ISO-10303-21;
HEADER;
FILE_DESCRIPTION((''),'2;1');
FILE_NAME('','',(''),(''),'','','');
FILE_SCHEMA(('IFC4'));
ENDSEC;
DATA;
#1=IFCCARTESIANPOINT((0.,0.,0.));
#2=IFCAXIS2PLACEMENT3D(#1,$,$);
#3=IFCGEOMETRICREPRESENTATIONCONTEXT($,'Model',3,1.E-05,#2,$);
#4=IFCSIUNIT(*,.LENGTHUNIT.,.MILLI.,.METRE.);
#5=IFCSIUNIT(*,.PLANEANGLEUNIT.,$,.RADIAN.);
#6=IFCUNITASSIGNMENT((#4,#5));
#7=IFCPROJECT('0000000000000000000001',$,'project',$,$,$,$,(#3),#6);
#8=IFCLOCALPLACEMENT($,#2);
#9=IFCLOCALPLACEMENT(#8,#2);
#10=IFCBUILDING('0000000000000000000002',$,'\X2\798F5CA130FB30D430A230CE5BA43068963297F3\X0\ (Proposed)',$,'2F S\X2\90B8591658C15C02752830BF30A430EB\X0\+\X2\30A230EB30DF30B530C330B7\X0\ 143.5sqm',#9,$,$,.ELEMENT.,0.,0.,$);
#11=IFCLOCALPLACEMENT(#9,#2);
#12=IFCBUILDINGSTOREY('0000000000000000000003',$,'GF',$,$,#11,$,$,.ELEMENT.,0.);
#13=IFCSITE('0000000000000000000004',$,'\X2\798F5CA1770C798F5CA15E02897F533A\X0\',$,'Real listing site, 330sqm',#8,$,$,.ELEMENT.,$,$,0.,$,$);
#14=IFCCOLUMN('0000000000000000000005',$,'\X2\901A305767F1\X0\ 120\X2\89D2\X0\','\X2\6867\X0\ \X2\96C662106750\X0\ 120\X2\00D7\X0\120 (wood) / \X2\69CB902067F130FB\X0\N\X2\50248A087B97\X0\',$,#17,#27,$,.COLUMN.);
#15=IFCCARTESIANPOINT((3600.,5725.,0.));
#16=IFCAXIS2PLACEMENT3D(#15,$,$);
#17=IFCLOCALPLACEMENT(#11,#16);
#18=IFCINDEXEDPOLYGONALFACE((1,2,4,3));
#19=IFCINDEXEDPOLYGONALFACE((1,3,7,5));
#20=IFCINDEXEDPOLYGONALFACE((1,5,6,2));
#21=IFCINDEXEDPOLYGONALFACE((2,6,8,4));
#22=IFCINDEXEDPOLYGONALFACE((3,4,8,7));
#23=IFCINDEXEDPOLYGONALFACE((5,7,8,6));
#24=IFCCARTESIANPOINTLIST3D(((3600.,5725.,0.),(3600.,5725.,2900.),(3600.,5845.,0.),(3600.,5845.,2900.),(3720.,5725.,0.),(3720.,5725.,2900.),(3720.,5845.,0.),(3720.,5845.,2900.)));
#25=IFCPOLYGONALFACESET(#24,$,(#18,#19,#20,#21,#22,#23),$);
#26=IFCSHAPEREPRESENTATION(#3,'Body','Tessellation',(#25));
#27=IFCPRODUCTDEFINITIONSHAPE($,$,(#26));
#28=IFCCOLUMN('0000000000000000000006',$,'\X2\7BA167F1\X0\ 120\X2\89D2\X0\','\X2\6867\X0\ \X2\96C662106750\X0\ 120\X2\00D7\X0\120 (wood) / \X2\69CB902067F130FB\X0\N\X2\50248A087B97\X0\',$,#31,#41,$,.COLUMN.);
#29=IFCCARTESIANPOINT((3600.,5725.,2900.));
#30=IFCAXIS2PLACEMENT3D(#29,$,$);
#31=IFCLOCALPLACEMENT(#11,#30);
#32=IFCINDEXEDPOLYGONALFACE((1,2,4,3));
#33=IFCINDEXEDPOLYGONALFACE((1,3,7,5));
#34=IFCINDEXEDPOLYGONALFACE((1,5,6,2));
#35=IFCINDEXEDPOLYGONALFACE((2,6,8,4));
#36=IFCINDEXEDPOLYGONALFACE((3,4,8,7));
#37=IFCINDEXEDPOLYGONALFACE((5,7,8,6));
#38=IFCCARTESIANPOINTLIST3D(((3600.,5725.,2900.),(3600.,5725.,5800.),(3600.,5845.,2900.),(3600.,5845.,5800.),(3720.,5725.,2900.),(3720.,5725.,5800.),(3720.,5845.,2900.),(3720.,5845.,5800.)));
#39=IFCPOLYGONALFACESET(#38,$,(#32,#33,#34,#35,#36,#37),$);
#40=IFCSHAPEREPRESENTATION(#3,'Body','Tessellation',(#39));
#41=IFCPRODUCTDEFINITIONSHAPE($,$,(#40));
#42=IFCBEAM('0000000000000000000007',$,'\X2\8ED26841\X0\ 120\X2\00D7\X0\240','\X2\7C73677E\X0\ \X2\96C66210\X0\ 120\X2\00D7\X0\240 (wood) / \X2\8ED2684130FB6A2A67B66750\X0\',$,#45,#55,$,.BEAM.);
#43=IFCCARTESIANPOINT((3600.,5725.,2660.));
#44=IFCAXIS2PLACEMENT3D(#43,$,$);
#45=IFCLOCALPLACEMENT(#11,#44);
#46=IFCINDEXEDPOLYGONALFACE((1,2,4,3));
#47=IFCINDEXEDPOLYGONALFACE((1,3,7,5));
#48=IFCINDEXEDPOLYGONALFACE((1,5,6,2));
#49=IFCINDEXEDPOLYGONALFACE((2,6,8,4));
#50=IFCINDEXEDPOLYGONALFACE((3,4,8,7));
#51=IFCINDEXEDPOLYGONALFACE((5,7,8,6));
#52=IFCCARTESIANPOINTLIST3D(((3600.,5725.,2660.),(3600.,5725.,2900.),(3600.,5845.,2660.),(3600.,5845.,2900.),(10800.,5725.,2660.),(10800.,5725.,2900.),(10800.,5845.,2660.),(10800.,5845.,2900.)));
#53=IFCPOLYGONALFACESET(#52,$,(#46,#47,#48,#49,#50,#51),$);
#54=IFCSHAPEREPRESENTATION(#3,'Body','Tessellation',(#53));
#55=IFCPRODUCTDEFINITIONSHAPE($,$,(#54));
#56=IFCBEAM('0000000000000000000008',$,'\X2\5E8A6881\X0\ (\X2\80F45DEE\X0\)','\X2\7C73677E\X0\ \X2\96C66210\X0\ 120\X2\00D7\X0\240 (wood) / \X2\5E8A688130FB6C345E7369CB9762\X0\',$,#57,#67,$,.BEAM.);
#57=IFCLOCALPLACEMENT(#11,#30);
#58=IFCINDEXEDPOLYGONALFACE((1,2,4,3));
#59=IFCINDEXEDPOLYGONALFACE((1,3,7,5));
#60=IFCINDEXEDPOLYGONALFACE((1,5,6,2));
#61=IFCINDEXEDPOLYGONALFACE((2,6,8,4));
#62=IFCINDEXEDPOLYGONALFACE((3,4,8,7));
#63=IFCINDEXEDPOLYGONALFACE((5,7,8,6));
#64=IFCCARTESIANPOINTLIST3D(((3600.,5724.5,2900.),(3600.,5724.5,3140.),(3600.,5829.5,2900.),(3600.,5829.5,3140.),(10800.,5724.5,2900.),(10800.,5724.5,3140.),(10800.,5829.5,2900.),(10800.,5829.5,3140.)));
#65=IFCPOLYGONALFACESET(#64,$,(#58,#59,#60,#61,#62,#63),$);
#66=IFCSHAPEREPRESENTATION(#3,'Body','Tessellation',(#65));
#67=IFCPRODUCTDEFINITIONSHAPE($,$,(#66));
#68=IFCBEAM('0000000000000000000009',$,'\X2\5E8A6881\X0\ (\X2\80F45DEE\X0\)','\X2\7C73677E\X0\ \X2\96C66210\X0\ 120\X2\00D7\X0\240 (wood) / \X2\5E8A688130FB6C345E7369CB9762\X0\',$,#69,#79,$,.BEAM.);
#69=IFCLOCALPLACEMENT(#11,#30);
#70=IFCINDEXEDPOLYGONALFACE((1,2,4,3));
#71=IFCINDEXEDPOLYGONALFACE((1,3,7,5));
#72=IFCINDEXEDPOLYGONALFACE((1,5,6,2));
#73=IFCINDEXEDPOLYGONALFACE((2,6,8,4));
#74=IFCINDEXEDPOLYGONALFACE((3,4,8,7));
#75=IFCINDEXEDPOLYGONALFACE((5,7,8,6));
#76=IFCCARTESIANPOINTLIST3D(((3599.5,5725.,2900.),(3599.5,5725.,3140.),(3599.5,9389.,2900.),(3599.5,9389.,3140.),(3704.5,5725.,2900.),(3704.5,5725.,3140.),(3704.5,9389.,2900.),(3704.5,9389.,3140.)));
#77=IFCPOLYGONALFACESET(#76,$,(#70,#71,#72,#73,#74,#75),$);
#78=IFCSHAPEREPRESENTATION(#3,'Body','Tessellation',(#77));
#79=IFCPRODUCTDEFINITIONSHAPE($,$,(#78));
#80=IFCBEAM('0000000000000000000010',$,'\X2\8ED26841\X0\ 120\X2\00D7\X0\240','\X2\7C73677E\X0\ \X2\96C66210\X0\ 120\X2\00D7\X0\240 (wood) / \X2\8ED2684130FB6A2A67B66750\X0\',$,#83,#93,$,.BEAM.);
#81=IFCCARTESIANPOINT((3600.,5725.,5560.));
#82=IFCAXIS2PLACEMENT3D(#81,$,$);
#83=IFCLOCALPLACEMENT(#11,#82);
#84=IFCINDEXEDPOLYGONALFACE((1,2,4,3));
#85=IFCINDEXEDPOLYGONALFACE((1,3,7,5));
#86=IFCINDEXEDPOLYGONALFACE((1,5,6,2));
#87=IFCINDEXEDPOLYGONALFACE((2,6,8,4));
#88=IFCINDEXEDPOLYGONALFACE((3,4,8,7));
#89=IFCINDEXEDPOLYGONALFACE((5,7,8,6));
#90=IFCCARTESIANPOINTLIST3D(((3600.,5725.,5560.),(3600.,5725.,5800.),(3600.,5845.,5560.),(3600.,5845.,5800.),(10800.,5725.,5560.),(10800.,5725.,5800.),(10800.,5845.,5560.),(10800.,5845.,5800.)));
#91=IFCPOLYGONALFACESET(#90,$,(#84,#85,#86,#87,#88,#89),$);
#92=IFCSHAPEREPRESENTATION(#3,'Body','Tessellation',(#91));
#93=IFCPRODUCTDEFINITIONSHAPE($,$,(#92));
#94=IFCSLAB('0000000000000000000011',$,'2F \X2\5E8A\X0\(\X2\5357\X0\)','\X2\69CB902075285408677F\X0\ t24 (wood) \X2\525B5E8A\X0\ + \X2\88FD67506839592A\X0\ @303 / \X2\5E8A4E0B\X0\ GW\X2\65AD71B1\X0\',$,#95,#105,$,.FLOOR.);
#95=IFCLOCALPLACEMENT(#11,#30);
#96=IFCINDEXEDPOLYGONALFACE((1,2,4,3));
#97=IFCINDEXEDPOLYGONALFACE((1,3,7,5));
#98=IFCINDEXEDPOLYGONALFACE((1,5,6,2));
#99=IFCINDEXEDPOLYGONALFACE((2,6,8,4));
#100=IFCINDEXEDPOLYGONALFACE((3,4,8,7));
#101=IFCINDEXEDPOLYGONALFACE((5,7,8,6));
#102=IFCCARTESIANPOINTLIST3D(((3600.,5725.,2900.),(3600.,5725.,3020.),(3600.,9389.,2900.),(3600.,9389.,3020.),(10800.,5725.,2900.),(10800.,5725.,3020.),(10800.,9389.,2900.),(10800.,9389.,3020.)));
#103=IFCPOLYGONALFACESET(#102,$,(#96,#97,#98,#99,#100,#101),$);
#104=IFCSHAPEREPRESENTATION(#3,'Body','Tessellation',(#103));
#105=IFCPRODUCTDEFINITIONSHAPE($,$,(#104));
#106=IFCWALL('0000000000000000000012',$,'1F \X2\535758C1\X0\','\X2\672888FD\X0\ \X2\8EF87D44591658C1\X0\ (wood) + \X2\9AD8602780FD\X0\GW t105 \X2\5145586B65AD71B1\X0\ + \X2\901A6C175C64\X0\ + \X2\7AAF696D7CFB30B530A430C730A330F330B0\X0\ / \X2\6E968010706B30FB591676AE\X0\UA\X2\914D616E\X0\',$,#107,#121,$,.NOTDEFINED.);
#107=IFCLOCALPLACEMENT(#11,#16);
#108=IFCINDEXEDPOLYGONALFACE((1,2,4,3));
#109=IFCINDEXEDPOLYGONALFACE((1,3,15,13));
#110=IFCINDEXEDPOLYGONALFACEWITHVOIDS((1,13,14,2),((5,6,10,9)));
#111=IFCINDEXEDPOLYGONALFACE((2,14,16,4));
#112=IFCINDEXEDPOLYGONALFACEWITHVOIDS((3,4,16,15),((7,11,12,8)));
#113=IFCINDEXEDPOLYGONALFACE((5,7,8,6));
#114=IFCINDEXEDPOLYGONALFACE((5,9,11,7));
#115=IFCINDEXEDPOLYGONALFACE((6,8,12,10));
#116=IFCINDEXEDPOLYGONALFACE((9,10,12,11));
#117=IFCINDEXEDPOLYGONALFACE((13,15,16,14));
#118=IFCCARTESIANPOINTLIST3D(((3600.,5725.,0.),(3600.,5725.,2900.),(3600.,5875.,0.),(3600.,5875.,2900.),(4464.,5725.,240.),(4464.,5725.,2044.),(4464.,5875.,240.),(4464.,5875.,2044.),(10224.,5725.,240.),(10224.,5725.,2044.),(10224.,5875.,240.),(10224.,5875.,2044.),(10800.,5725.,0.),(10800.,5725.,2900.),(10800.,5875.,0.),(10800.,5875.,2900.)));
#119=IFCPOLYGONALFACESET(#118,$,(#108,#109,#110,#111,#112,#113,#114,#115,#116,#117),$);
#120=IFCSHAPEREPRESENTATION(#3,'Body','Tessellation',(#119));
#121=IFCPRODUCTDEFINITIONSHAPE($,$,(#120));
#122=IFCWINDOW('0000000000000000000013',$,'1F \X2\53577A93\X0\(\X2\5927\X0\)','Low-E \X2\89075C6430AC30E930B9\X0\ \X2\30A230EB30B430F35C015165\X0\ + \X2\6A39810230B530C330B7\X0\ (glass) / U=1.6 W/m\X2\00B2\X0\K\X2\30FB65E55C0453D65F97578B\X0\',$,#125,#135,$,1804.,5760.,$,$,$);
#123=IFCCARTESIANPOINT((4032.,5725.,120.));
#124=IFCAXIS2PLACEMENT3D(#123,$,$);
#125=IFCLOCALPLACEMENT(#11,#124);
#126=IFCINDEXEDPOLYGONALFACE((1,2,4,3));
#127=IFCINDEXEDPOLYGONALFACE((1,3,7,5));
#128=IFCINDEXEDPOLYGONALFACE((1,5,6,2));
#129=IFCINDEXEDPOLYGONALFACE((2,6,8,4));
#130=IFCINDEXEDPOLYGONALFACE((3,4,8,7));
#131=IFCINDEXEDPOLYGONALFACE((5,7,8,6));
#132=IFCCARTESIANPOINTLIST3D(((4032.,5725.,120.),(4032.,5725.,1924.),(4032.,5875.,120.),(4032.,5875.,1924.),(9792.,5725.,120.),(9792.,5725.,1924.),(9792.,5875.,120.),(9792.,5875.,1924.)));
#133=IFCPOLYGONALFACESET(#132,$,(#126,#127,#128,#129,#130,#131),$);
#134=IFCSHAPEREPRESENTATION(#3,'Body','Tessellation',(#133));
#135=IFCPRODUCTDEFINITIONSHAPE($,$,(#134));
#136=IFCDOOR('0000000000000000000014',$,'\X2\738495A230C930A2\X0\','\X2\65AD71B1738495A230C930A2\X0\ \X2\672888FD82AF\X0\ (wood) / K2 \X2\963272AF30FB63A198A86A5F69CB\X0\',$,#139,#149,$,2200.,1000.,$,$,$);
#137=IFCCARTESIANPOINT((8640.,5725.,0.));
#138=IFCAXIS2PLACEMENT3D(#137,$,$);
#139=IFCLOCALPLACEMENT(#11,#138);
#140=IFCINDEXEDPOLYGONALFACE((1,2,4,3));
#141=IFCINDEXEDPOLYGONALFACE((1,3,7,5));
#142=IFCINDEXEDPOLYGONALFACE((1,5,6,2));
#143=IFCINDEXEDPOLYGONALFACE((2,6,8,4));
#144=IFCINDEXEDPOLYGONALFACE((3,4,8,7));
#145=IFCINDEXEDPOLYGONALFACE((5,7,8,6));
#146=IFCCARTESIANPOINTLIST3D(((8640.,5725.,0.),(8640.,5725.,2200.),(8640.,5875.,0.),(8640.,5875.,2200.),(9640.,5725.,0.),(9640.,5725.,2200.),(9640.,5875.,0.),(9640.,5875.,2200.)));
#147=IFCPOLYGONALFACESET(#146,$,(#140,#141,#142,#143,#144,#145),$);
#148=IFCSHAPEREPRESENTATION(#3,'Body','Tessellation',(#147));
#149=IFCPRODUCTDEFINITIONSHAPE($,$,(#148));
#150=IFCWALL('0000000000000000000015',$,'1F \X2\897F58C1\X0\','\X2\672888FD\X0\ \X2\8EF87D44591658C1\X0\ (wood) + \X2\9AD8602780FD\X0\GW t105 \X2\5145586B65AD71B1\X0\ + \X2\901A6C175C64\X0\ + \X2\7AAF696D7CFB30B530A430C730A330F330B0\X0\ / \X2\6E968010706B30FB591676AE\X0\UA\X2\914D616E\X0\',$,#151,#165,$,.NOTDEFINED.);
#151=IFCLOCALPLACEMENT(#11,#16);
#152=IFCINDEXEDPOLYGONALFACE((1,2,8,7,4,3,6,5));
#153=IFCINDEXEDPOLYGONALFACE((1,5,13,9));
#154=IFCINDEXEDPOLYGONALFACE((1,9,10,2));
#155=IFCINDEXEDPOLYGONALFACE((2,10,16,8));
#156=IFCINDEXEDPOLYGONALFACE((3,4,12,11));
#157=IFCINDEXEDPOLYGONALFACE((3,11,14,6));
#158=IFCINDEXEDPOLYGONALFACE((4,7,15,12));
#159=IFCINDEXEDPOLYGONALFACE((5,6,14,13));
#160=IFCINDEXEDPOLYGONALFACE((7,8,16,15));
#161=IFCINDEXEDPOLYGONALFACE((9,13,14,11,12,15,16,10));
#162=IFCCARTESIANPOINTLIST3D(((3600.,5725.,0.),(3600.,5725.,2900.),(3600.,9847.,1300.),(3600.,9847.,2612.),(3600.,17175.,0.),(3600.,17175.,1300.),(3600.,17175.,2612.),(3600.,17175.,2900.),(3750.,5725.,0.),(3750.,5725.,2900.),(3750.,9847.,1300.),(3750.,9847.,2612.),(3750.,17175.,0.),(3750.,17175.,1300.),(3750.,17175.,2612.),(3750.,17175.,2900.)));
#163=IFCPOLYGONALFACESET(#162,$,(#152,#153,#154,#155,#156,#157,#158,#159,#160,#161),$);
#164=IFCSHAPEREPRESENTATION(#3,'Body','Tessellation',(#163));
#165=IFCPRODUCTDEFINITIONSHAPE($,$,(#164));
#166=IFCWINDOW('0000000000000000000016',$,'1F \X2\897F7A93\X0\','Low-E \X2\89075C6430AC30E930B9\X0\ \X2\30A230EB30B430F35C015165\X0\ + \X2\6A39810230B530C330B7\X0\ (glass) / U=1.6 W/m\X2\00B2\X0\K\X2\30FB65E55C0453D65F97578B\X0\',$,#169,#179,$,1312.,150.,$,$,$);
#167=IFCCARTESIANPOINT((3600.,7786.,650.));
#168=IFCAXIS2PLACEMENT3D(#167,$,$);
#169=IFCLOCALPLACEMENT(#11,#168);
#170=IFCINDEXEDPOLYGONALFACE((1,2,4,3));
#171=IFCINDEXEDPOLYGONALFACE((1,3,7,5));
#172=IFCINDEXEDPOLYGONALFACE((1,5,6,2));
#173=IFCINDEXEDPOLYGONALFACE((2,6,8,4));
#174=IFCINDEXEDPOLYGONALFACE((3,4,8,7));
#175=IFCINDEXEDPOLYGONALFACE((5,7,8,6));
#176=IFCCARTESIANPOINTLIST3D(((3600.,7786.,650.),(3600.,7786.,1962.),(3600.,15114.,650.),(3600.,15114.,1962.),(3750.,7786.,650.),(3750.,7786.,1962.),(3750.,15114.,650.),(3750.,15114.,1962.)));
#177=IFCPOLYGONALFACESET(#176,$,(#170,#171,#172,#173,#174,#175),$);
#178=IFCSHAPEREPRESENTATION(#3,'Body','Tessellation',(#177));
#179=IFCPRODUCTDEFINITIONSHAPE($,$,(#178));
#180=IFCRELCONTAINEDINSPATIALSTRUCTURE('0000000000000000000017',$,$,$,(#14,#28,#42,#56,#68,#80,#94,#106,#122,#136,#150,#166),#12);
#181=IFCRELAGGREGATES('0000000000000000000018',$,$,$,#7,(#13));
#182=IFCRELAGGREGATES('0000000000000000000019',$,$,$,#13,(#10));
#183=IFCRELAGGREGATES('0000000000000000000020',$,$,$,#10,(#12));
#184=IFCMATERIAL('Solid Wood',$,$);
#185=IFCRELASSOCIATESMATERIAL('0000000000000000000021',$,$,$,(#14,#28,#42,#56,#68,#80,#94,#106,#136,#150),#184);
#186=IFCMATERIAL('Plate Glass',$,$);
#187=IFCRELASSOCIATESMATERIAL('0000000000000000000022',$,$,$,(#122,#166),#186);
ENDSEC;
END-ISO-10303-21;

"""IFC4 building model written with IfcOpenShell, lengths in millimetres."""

from ifc_helpers import new_model, si_unit, frame, frame_2d, origin, place, context, project, spatial, rectangle, extrude, material, element, fill, save


model = new_model("IFC4")

# Units and contexts
model_context = context("Model", 3, precision=1e-05, world=origin())
ifc_project = project(units=[si_unit("LENGTHUNIT", "METRE", prefix="MILLI"), si_unit("PLANEANGLEUNIT", "RADIAN")], contexts=[model_context])

# Site, building, storey
site_placement = place(None, origin())
site = spatial("IfcSite", under=ifc_project, at=site_placement, Name="福岡県福岡市西区", ObjectType="Real listing site, 330sqm", CompositionType="ELEMENT", RefElevation=0.0)
building_placement = place(site_placement, origin())
building = spatial("IfcBuilding", under=site, at=building_placement, Name="福岡・ピアノ室と防音 (Proposed)", ObjectType="2F S邸外壁専用タイル+アルミサッシ 143.5sqm", CompositionType="ELEMENT", ElevationOfRefHeight=0.0, ElevationOfTerrain=0.0)
storey_placement = place(building_placement, origin())
storey = spatial("IfcBuildingStorey", under=building, at=storey_placement, Name="GF", CompositionType="ELEMENT", Elevation=0.0)

# Columns
ifc_material_1 = material(Name="Solid Wood")
column_1_placement = place(storey_placement, frame((3600.0, 5725.0, 0.0)))
element("IfcColumn", 1, at=column_1_placement, inside=storey, material=ifc_material_1, Name="通し柱 120角", Description="桧 集成材 120×120 (wood) / 構造柱・N値計算", PredefinedType="COLUMN", context=model_context, shape_type="SweptSolid", body=[
    extrude(rectangle(XDim=120.0, YDim=120.0, at=frame_2d((60.0, 60.0))), frame((3600.0, 5725.0, 0.0)), (0.0, 0.0, 1.0), 2900.0),
])
column_2_placement = place(storey_placement, frame((3600.0, 5725.0, 2900.0)))
element("IfcColumn", 2, at=column_2_placement, inside=storey, material=ifc_material_1, Name="管柱 120角", Description="桧 集成材 120×120 (wood) / 構造柱・N値計算", PredefinedType="COLUMN", context=model_context, shape_type="SweptSolid", body=[
    extrude(rectangle(XDim=120.0, YDim=120.0, at=frame_2d((60.0, 60.0))), frame((3600.0, 5725.0, 2900.0)), (0.0, 0.0, 1.0), 2900.0),
])

# Beams
beam_1_placement = place(storey_placement, frame((3600.0, 5725.0, 2660.0)))
element("IfcBeam", 3, at=beam_1_placement, inside=storey, material=ifc_material_1, Name="軒桁 120×240", Description="米松 集成 120×240 (wood) / 軒桁・横架材", PredefinedType="BEAM", context=model_context, shape_type="SweptSolid", body=[
    extrude(rectangle(XDim=7200.0, YDim=120.0, at=frame_2d((3600.0, 60.0))), frame((3600.0, 5725.0, 2660.0)), (0.0, 0.0, 1.0), 240.0),
])
beam_2_placement = place(storey_placement, frame((3600.0, 5725.0, 2900.0)))
element("IfcBeam", 4, at=beam_2_placement, inside=storey, material=ifc_material_1, Name="床梁 (胴差)", Description="米松 集成 120×240 (wood) / 床梁・水平構面", PredefinedType="BEAM", context=model_context, shape_type="SweptSolid", body=[
    extrude(rectangle(XDim=7200.0, YDim=105.0, at=frame_2d((3600.0, 52.0))), frame((3600.0, 5725.0, 2900.0)), (0.0, 0.0, 1.0), 240.0),
])
beam_3_placement = place(storey_placement, frame((3600.0, 5725.0, 2900.0)))
element("IfcBeam", 5, at=beam_3_placement, inside=storey, material=ifc_material_1, Name="床梁 (胴差)", Description="米松 集成 120×240 (wood) / 床梁・水平構面", PredefinedType="BEAM", context=model_context, shape_type="SweptSolid", body=[
    extrude(rectangle(XDim=105.0, YDim=3664.0, at=frame_2d((52.0, 1832.0))), frame((3600.0, 5725.0, 2900.0)), (0.0, 0.0, 1.0), 240.0),
])
beam_4_placement = place(storey_placement, frame((3600.0, 5725.0, 5560.0)))
element("IfcBeam", 6, at=beam_4_placement, inside=storey, material=ifc_material_1, Name="軒桁 120×240", Description="米松 集成 120×240 (wood) / 軒桁・横架材", PredefinedType="BEAM", context=model_context, shape_type="SweptSolid", body=[
    extrude(rectangle(XDim=7200.0, YDim=120.0, at=frame_2d((3600.0, 60.0))), frame((3600.0, 5725.0, 5560.0)), (0.0, 0.0, 1.0), 240.0),
])

# Slab
slab_1_placement = place(storey_placement, frame((3600.0, 5725.0, 2900.0)))
element("IfcSlab", 7, at=slab_1_placement, inside=storey, material=ifc_material_1, Name="2F 床(南)", Description="構造用合板 t24 (wood) 剛床 + 製材根太 @303 / 床下 GW断熱", PredefinedType="FLOOR", context=model_context, shape_type="SweptSolid", body=[
    extrude(rectangle(XDim=7200.0, YDim=3664.0, at=frame_2d((3600.0, 1832.0))), frame((3600.0, 5725.0, 2900.0)), (0.0, 0.0, 1.0), 120.0),
])

# Wall, openings, window, door
wall_1_placement = place(storey_placement, frame((3600.0, 5725.0, 0.0)))
wall_1 = element("IfcWall", 8, at=wall_1_placement, inside=storey, material=ifc_material_1, Name="1F 南壁", Description="木製 軸組外壁 (wood) + 高性能GW t105 充填断熱 + 通気層 + 窯業系サイディング / 準耐火・外皮UA配慮", PredefinedType="NOTDEFINED", context=model_context, shape_type="SweptSolid", body=[
    extrude(rectangle(XDim=7200.0, YDim=150.0, at=frame_2d((3600.0, 75.0))), frame((3600.0, 5725.0, 0.0)), (0.0, 0.0, 1.0), 2900.0),
])
opening_1_placement = place(storey_placement, frame((4032.0, 5725.0, 120.0)))
opening_1 = element("IfcOpeningElement", 9, at=opening_1_placement, cuts=wall_1, PredefinedType="NOTDEFINED", context=model_context, shape_type="SweptSolid", body=[
    extrude(rectangle(XDim=5760.0, YDim=150.0, at=frame_2d((2880.0, 75.0))), frame((4032.0, 5725.0, 120.0)), (0.0, 0.0, 1.0), 1804.0),
])
opening_2_placement = place(storey_placement, frame((8640.0, 5725.0, 0.0)))
opening_2 = element("IfcOpeningElement", 10, at=opening_2_placement, cuts=wall_1, PredefinedType="NOTDEFINED", context=model_context, shape_type="SweptSolid", body=[
    extrude(rectangle(XDim=1000.0, YDim=150.0, at=frame_2d((500.0, 75.0))), frame((8640.0, 5725.0, 0.0)), (0.0, 0.0, 1.0), 2200.0),
])
ifc_material_2 = material(Name="Plate Glass")
window_1_placement = place(storey_placement, frame((4032.0, 5725.0, 120.0)))
window_1 = element("IfcWindow", 11, at=window_1_placement, inside=storey, material=ifc_material_2, Name="1F 南窓(大)", Description="Low-E 複層ガラス アルゴン封入 + 樹脂サッシ (glass) / U=1.6 W/m²K・日射取得型", OverallHeight=1804.0, OverallWidth=5760.0, context=model_context, shape_type="SweptSolid", body=[
    extrude(rectangle(XDim=5760.0, YDim=150.0, at=frame_2d((2880.0, 75.0))), frame((4032.0, 5725.0, 120.0)), (0.0, 0.0, 1.0), 1804.0),
])
fill(opening_1, window_1)
door_placement = place(storey_placement, frame((8640.0, 5725.0, 0.0)))
door = element("IfcDoor", 12, at=door_placement, inside=storey, material=ifc_material_1, Name="玄関ドア", Description="断熱玄関ドア 木製芯 (wood) / K2 防犯・採風機構", OverallHeight=2200.0, OverallWidth=1000.0, context=model_context, shape_type="SweptSolid", body=[
    extrude(rectangle(XDim=1000.0, YDim=150.0, at=frame_2d((500.0, 75.0))), frame((8640.0, 5725.0, 0.0)), (0.0, 0.0, 1.0), 2200.0),
])
fill(opening_2, door)

# Wall, opening, window
wall_2_placement = place(storey_placement, frame((3600.0, 5725.0, 0.0)))
wall_2 = element("IfcWall", 13, at=wall_2_placement, inside=storey, material=ifc_material_1, Name="1F 西壁", Description="木製 軸組外壁 (wood) + 高性能GW t105 充填断熱 + 通気層 + 窯業系サイディング / 準耐火・外皮UA配慮", PredefinedType="NOTDEFINED", context=model_context, shape_type="SweptSolid", body=[
    extrude(rectangle(XDim=150.0, YDim=11450.0, at=frame_2d((75.0, 5725.0))), frame((3600.0, 5725.0, 0.0)), (0.0, 0.0, 1.0), 2900.0),
])
opening_3_placement = place(storey_placement, frame((3600.0, 7786.0, 650.0)))
opening_3 = element("IfcOpeningElement", 14, at=opening_3_placement, cuts=wall_2, PredefinedType="NOTDEFINED", context=model_context, shape_type="SweptSolid", body=[
    extrude(rectangle(XDim=150.0, YDim=7328.0, at=frame_2d((75.0, 3664.0))), frame((3600.0, 7786.0, 650.0)), (0.0, 0.0, 1.0), 1312.0),
])
window_2_placement = place(storey_placement, frame((3600.0, 7786.0, 650.0)))
window_2 = element("IfcWindow", 15, at=window_2_placement, inside=storey, material=ifc_material_2, Name="1F 西窓", Description="Low-E 複層ガラス アルゴン封入 + 樹脂サッシ (glass) / U=1.6 W/m²K・日射取得型", OverallHeight=1312.0, OverallWidth=150.0, context=model_context, shape_type="SweptSolid", body=[
    extrude(rectangle(XDim=150.0, YDim=7328.0, at=frame_2d((75.0, 3664.0))), frame((3600.0, 7786.0, 650.0)), (0.0, 0.0, 1.0), 1312.0),
])
fill(opening_3, window_2)

save(model, "model.ifc")
